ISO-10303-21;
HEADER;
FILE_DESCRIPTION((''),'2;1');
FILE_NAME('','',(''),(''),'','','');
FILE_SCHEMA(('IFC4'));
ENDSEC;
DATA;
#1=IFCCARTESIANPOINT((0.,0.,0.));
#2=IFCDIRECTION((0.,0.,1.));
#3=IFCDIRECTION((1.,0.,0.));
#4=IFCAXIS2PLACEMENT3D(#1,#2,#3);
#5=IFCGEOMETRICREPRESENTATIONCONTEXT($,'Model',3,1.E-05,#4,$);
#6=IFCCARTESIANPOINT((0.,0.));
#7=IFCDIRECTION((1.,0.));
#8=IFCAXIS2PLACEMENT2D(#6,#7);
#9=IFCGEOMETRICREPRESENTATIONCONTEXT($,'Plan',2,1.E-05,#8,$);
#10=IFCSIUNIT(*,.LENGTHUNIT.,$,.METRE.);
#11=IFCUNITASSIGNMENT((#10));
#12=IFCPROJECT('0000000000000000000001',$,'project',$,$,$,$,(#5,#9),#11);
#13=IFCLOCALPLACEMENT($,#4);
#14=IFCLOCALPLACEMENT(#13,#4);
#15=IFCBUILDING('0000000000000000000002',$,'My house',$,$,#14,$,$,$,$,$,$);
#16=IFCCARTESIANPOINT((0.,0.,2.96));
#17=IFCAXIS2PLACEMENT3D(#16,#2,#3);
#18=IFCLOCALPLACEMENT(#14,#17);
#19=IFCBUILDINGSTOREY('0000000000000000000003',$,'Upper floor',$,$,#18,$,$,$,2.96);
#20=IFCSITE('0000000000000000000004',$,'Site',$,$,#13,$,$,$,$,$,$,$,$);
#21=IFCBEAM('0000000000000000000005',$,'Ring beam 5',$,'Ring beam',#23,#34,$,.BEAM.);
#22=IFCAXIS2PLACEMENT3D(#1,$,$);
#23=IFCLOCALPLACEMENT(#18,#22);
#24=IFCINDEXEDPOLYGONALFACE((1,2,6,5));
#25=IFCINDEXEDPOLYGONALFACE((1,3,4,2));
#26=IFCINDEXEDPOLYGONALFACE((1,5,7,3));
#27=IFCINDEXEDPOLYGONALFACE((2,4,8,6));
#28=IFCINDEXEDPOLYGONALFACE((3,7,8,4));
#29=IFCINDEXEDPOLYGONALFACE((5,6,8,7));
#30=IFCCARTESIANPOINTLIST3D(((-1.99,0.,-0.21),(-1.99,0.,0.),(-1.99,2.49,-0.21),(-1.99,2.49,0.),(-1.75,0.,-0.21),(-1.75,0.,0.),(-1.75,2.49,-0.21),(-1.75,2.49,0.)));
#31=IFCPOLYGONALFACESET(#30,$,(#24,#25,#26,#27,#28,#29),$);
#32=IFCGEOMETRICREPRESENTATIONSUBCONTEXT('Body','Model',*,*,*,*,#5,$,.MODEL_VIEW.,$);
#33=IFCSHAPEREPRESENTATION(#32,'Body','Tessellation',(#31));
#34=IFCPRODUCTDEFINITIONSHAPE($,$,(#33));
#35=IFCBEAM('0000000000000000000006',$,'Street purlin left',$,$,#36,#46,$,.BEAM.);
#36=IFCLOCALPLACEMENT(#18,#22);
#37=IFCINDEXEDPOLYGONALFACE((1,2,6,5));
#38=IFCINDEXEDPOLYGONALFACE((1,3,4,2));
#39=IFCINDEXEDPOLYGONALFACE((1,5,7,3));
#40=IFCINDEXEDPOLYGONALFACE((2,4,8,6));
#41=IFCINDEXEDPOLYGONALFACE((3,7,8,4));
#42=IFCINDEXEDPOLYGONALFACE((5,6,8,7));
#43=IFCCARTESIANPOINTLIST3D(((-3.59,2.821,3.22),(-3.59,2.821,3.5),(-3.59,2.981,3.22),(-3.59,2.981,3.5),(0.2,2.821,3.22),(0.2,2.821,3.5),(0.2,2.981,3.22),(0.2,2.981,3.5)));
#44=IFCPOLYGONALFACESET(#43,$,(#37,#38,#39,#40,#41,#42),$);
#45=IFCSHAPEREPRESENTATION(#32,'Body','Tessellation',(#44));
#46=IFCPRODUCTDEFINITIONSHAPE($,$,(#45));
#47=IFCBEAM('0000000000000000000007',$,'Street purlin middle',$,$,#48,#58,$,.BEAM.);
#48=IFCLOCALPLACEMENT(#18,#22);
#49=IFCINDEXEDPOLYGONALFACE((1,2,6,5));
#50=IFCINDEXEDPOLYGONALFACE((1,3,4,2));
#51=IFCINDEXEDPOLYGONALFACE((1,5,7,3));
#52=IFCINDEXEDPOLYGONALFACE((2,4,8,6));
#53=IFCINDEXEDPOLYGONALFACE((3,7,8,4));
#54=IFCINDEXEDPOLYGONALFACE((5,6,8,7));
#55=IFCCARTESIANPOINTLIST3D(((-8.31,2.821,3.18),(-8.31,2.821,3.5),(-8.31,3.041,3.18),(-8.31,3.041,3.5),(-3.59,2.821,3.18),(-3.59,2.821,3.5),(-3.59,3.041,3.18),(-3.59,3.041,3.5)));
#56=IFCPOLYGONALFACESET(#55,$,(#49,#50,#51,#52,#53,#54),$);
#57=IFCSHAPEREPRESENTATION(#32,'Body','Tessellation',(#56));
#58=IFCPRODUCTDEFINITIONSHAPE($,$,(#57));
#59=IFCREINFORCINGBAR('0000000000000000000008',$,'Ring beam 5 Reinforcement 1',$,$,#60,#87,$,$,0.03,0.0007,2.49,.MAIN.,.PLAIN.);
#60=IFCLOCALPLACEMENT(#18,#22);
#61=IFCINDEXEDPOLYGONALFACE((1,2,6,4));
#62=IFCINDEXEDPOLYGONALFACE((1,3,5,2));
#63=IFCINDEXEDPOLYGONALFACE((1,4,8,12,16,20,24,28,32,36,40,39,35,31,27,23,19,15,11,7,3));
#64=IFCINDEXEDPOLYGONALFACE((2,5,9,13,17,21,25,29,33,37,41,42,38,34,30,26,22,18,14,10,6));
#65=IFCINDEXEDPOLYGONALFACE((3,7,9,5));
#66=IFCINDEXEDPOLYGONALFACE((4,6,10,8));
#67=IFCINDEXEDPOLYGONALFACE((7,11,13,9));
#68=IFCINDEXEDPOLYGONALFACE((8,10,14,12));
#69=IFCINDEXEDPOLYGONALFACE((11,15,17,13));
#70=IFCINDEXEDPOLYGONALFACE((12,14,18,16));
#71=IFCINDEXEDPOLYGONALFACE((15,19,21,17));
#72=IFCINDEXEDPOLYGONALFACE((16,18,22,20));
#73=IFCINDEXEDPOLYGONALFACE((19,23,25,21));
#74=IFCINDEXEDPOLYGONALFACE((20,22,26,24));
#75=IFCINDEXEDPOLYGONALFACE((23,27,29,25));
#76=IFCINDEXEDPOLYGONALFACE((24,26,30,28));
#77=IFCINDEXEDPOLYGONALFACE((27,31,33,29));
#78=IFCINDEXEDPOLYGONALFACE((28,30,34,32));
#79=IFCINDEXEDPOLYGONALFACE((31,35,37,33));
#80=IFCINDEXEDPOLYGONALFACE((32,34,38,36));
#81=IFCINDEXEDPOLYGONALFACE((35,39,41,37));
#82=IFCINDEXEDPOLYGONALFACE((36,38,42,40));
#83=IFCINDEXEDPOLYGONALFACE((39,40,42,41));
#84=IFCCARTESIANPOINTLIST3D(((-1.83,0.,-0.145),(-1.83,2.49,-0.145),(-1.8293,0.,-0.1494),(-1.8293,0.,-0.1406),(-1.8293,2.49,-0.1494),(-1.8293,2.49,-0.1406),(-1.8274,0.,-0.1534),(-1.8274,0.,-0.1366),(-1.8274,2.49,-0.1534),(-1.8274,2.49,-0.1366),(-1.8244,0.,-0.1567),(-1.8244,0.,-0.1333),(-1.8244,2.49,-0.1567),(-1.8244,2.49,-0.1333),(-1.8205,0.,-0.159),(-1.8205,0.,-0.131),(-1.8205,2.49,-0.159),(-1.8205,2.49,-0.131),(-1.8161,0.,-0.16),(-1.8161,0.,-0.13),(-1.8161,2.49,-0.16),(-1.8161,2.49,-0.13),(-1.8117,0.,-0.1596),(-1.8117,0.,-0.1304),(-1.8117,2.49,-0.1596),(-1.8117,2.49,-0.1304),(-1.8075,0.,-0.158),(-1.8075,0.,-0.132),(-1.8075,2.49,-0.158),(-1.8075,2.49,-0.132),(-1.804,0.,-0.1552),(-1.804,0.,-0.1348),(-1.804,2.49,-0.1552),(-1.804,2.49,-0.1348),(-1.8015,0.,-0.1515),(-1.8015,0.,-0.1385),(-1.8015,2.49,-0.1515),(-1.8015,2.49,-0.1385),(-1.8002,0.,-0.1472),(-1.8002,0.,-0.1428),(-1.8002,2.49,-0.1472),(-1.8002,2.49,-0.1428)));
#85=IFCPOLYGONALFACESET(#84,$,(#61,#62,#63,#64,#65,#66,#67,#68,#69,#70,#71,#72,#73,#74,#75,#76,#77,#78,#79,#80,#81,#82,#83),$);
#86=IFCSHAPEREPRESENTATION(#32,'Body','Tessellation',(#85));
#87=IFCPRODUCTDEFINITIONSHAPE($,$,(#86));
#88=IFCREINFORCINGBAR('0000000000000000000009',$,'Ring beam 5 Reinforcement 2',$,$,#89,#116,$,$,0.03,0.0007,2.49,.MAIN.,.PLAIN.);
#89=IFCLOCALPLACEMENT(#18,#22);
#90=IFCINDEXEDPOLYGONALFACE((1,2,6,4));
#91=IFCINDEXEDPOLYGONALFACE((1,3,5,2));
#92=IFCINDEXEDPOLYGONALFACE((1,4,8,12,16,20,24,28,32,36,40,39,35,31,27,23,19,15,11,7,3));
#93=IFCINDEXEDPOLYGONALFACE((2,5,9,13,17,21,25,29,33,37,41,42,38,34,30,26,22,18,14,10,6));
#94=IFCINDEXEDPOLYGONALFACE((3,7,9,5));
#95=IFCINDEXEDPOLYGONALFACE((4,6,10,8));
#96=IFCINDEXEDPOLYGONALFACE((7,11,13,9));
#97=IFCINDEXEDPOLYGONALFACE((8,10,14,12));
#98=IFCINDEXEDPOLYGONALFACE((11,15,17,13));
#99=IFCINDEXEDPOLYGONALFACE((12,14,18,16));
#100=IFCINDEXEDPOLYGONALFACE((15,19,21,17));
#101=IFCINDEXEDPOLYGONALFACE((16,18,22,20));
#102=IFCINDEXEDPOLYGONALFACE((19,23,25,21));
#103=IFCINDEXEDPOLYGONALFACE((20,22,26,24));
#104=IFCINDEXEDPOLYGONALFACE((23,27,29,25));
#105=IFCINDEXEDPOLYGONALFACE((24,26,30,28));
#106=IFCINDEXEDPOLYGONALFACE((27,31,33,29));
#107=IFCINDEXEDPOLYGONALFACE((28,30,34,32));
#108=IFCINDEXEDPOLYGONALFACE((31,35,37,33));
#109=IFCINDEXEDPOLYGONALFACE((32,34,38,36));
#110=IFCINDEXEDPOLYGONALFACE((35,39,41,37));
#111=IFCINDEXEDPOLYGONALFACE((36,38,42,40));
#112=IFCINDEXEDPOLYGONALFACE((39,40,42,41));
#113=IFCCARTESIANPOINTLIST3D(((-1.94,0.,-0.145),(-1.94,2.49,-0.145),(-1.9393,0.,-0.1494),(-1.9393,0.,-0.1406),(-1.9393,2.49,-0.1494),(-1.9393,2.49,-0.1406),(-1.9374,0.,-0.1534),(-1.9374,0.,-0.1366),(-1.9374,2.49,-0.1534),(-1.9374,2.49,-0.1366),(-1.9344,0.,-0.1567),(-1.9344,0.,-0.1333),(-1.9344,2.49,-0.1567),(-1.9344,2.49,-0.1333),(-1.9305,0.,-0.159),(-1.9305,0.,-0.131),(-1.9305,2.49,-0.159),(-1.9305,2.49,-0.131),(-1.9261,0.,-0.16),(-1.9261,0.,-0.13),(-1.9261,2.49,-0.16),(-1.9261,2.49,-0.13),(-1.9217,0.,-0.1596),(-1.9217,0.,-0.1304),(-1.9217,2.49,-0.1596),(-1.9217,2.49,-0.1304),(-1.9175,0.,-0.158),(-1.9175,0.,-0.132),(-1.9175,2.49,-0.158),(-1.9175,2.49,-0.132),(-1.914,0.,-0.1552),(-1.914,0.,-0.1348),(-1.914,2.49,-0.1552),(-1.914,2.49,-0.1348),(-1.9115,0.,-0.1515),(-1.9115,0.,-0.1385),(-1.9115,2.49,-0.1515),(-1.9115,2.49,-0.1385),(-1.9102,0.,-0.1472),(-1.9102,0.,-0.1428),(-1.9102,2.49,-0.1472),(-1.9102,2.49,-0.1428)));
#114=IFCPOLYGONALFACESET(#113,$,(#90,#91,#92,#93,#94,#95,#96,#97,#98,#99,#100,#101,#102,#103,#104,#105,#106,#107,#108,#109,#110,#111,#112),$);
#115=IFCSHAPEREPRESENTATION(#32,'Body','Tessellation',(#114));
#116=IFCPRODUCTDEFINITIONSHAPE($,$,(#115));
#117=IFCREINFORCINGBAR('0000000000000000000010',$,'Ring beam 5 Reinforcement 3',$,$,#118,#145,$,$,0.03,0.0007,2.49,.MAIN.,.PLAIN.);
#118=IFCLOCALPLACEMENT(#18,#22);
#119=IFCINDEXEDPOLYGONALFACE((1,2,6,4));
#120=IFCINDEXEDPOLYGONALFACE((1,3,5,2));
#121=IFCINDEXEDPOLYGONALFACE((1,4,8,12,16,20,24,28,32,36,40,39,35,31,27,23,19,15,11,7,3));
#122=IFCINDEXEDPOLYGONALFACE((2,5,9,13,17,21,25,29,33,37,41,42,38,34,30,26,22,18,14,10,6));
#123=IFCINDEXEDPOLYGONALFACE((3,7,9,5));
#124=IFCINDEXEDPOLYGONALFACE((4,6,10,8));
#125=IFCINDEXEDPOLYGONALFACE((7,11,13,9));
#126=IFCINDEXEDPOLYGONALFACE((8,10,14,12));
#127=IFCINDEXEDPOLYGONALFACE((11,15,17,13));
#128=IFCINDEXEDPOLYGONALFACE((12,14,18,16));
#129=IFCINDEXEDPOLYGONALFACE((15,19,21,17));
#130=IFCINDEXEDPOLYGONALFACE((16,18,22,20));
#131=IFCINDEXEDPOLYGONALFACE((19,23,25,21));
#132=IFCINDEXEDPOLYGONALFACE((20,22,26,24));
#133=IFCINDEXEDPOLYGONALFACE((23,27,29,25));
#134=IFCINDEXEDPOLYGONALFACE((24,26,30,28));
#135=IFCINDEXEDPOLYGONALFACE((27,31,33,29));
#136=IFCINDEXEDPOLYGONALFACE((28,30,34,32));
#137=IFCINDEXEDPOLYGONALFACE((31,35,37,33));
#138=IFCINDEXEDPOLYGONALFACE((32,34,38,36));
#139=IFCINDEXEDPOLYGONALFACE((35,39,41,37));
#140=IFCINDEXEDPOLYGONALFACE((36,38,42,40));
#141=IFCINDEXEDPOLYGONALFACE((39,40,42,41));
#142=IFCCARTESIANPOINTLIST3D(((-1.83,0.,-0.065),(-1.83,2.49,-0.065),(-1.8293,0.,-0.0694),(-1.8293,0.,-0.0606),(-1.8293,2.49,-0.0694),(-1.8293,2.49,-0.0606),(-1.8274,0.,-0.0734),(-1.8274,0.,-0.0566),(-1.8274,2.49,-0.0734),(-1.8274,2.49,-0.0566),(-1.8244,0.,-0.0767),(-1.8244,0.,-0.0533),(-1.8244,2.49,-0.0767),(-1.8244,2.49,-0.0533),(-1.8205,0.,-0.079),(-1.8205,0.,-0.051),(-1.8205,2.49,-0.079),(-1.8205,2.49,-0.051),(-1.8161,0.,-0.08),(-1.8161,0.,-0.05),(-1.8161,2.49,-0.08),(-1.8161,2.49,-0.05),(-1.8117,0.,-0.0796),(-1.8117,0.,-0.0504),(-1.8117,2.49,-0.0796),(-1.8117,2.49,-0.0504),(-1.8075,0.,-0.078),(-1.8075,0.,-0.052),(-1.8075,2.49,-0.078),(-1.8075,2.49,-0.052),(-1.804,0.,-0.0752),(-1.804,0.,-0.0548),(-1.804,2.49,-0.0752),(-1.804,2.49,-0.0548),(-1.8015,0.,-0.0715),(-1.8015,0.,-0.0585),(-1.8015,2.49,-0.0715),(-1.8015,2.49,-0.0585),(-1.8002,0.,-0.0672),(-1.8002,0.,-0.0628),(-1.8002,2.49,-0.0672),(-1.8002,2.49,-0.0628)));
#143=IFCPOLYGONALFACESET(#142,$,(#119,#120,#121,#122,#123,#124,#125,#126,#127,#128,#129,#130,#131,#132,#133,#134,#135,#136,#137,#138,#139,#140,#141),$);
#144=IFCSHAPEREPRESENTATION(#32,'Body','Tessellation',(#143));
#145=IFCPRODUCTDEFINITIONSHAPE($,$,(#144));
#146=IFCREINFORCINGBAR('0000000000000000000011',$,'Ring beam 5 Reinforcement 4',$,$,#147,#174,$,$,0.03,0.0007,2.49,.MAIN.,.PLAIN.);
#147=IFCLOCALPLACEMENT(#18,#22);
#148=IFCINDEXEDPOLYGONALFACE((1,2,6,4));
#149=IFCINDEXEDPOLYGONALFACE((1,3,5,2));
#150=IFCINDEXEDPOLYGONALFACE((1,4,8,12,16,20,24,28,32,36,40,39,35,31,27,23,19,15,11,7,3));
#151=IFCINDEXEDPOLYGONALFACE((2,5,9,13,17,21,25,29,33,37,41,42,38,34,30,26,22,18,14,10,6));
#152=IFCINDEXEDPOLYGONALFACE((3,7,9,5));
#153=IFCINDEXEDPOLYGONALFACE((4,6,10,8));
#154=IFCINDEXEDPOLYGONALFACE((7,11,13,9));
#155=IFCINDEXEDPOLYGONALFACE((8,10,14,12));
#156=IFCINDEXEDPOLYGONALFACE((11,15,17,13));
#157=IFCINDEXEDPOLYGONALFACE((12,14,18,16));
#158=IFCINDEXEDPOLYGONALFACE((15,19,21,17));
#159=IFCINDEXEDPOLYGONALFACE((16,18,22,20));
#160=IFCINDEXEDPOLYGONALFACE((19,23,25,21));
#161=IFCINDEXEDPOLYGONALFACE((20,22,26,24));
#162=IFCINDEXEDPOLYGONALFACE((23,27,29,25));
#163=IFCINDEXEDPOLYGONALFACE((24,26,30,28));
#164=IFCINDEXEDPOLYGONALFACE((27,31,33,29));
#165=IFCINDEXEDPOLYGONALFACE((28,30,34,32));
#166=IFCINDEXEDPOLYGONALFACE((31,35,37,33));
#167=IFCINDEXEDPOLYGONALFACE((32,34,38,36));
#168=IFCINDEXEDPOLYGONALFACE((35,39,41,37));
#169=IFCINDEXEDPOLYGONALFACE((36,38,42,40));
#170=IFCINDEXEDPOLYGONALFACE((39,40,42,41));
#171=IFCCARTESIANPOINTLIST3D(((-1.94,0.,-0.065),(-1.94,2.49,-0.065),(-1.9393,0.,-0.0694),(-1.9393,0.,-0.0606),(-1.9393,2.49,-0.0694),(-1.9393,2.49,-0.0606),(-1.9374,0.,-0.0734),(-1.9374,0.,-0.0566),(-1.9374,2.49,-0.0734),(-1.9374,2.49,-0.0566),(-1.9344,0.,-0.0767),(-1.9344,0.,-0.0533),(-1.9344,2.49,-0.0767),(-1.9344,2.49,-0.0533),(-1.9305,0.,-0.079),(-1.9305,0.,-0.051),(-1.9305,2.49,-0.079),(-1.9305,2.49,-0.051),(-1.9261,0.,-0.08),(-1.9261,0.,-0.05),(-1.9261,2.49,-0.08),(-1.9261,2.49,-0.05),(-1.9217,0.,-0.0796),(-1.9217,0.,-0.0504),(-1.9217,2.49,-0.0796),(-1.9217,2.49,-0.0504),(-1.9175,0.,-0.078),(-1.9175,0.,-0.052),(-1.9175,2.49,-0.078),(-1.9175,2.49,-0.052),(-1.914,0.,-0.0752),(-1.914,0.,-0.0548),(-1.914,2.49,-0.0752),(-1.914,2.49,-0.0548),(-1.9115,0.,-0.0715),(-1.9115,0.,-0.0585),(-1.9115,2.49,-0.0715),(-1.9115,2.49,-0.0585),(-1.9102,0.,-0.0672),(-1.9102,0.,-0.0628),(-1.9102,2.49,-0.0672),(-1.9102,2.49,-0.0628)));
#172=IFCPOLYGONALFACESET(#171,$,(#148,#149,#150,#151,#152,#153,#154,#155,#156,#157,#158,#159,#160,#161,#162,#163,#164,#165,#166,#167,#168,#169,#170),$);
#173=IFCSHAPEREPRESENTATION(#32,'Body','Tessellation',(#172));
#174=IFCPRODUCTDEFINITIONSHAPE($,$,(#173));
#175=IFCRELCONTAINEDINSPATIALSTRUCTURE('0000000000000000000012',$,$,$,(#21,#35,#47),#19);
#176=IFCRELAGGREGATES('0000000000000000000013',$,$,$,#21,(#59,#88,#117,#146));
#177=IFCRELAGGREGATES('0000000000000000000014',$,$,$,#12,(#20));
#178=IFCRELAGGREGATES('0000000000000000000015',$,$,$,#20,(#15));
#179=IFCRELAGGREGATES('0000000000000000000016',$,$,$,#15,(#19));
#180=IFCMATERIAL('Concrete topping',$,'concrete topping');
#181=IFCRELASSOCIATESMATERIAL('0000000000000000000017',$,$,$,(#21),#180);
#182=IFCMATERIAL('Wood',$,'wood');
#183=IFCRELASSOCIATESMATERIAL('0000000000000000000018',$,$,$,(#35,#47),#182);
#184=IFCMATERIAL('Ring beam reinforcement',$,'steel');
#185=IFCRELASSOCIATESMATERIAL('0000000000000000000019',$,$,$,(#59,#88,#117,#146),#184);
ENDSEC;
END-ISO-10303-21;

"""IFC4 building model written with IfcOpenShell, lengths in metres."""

from ifc_helpers import new_model, si_unit, frame, origin_with_axes, origin_2d, origin_2d_with_axis, place, context, subcontext, project, spatial, circle_curve, rectangle, outline, extrude, source, transform, mapped, material, element, aggregate, save


model = new_model("IFC4")

# Units and contexts
model_context = context("Model", 3, precision=1e-05, world=origin_with_axes())
plan_context = context("Plan", 2, precision=1e-05, world=origin_2d_with_axis())
body_context_1 = subcontext(model_context, "Body", "Model", "MODEL_VIEW")
ifc_project = project(units=[si_unit("LENGTHUNIT", "METRE")], contexts=[model_context, plan_context])

# Site, building, storey
site_placement = place(None, origin_with_axes())
site = spatial("IfcSite", under=ifc_project, at=site_placement, Name="Site")
building_placement = place(site_placement, origin_with_axes())
building = spatial("IfcBuilding", under=site, at=building_placement, Name="My house")
storey_placement = place(building_placement, frame((0.0, 0.0, 2.96), z_axis=(0.0, 0.0, 1.0), x_axis=(1.0, 0.0, 0.0)))
storey = spatial("IfcBuildingStorey", under=building, at=storey_placement, Name="Upper floor", Elevation=2.96)

# Beam
ifc_material_1 = material(Name="Concrete topping", Category="concrete topping")
shared_shape_1 = source(origin_with_axes(), body_context_1, "Body", "SweptSolid", [
    extrude(rectangle(XDim=0.24, YDim=0.21), frame((0.0, 0.0, 0.0), z_axis=(1.0, 0.0, 0.0), x_axis=(0.0, 1.0, 0.0)), (0.0, 0.0, 1.0), 2.49),
])
beam_1_placement = place(storey_placement, frame((-1.87, 2.49, -0.105), z_axis=(0.0, 0.0, 1.0), x_axis=(0.0, 1.0, 0.0)))
beam_1 = element("IfcBeam", 1, at=beam_1_placement, inside=storey, material=ifc_material_1, Name="Ring beam 5", ObjectType="Ring beam", PredefinedType="BEAM", context=body_context_1, shape_type="MappedRepresentation", body=[
    mapped(shared_shape_1, transform((0.0, 0.0, 0.0), x_axis=(-1.0, 0.0, 0.0), y_axis=(0.0, 1.0, 0.0), z_axis=(0.0, 0.0, 1.0), scale=1.0)),
])

# Beams
ifc_material_2 = material(Name="Wood", Category="wood")
shared_shape_2 = source(origin_with_axes(), body_context_1, "Body", "SweptSolid", [
    extrude(rectangle(XDim=0.16, YDim=0.28), frame((0.0, 0.0, 0.0), z_axis=(1.0, 0.0, 0.0), x_axis=(0.0, 1.0, 0.0)), (0.0, 0.0, 1.0), 3.79),
])
beam_2_placement = place(storey_placement, frame((0.2, 2.901, 3.36), z_axis=(0.0, 0.0, 1.0), x_axis=(1.0, 0.0, 0.0)))
element("IfcBeam", 2, at=beam_2_placement, inside=storey, material=ifc_material_2, Name="Street purlin left", PredefinedType="BEAM", context=body_context_1, shape_type="MappedRepresentation", body=[
    mapped(shared_shape_2, transform((0.0, 0.0, 0.0), x_axis=(-1.0, 0.0, 0.0), y_axis=(0.0, 1.0, 0.0), z_axis=(0.0, 0.0, 1.0), scale=1.0)),
])
shared_shape_3 = source(origin_with_axes(), body_context_1, "Body", "SweptSolid", [
    extrude(rectangle(XDim=0.22, YDim=0.32), frame((0.0, 0.0, 0.0), z_axis=(1.0, 0.0, 0.0), x_axis=(0.0, 1.0, 0.0)), (0.0, 0.0, 1.0), 4.72),
])
beam_3_placement = place(storey_placement, frame((-3.59, 2.931, 3.34), z_axis=(0.0, 0.0, 1.0), x_axis=(1.0, 0.0, 0.0)))
element("IfcBeam", 3, at=beam_3_placement, inside=storey, material=ifc_material_2, Name="Street purlin middle", PredefinedType="BEAM", context=body_context_1, shape_type="MappedRepresentation", body=[
    mapped(shared_shape_3, transform((0.0, 0.0, 0.0), x_axis=(-1.0, 0.0, 0.0), y_axis=(0.0, 1.0, 0.0), z_axis=(0.0, 0.0, 1.0), scale=1.0)),
])

# Reinforcing bars
ifc_material_3 = material(Name="Ring beam reinforcement", Category="steel")
shared_shape_4 = source(origin_with_axes(), body_context_1, "Body", "SweptSolid", [
    extrude(outline(circle_curve(origin_2d(), 0.015)), frame((0.0, 0.0, 0.0), z_axis=(1.0, 0.0, 0.0), x_axis=(0.0, 1.0, 0.0)), (0.0, 0.0, 1.0), 2.49),
])
reinforcing_bar_1_placement = place(beam_1_placement, frame((0.0, -0.055, -0.04), z_axis=(0.0, 0.0, 1.0), x_axis=(1.0, 0.0, 0.0)))
reinforcing_bar_1 = element("IfcReinforcingBar", 4, at=reinforcing_bar_1_placement, material=ifc_material_3, Name="Ring beam 5 Reinforcement 1", BarLength=2.49, BarSurface="PLAIN", CrossSectionArea=0.0007, NominalDiameter=0.03, PredefinedType="MAIN", context=body_context_1, shape_type="MappedRepresentation", body=[
    mapped(shared_shape_4, transform((0.0, 0.0, 0.0), x_axis=(-1.0, 0.0, 0.0), y_axis=(0.0, 1.0, 0.0), z_axis=(0.0, 0.0, 1.0), scale=1.0)),
])
shared_shape_5 = source(origin_with_axes(), body_context_1, "Body", "SweptSolid", [
    extrude(outline(circle_curve(origin_2d(), 0.015)), frame((0.0, 0.0, 0.0), z_axis=(1.0, 0.0, 0.0), x_axis=(0.0, 1.0, 0.0)), (0.0, 0.0, 1.0), 2.49),
])
reinforcing_bar_2_placement = place(beam_1_placement, frame((0.0, 0.055, -0.04), z_axis=(0.0, 0.0, 1.0), x_axis=(1.0, 0.0, 0.0)))
reinforcing_bar_2 = element("IfcReinforcingBar", 5, at=reinforcing_bar_2_placement, material=ifc_material_3, Name="Ring beam 5 Reinforcement 2", BarLength=2.49, BarSurface="PLAIN", CrossSectionArea=0.0007, NominalDiameter=0.03, PredefinedType="MAIN", context=body_context_1, shape_type="MappedRepresentation", body=[
    mapped(shared_shape_5, transform((0.0, 0.0, 0.0), x_axis=(-1.0, 0.0, 0.0), y_axis=(0.0, 1.0, 0.0), z_axis=(0.0, 0.0, 1.0), scale=1.0)),
])
shared_shape_6 = source(origin_with_axes(), body_context_1, "Body", "SweptSolid", [
    extrude(outline(circle_curve(origin_2d(), 0.015)), frame((0.0, 0.0, 0.0), z_axis=(1.0, 0.0, 0.0), x_axis=(0.0, 1.0, 0.0)), (0.0, 0.0, 1.0), 2.49),
])
reinforcing_bar_3_placement = place(beam_1_placement, frame((0.0, -0.055, 0.04), z_axis=(0.0, 0.0, 1.0), x_axis=(1.0, 0.0, 0.0)))
reinforcing_bar_3 = element("IfcReinforcingBar", 6, at=reinforcing_bar_3_placement, material=ifc_material_3, Name="Ring beam 5 Reinforcement 3", BarLength=2.49, BarSurface="PLAIN", CrossSectionArea=0.0007, NominalDiameter=0.03, PredefinedType="MAIN", context=body_context_1, shape_type="MappedRepresentation", body=[
    mapped(shared_shape_6, transform((0.0, 0.0, 0.0), x_axis=(-1.0, 0.0, 0.0), y_axis=(0.0, 1.0, 0.0), z_axis=(0.0, 0.0, 1.0), scale=1.0)),
])
shared_shape_7 = source(origin_with_axes(), body_context_1, "Body", "SweptSolid", [
    extrude(outline(circle_curve(origin_2d(), 0.015)), frame((0.0, 0.0, 0.0), z_axis=(1.0, 0.0, 0.0), x_axis=(0.0, 1.0, 0.0)), (0.0, 0.0, 1.0), 2.49),
])
reinforcing_bar_4_placement = place(beam_1_placement, frame((0.0, 0.055, 0.04), z_axis=(0.0, 0.0, 1.0), x_axis=(1.0, 0.0, 0.0)))
reinforcing_bar_4 = element("IfcReinforcingBar", 7, at=reinforcing_bar_4_placement, material=ifc_material_3, Name="Ring beam 5 Reinforcement 4", BarLength=2.49, BarSurface="PLAIN", CrossSectionArea=0.0007, NominalDiameter=0.03, PredefinedType="MAIN", context=body_context_1, shape_type="MappedRepresentation", body=[
    mapped(shared_shape_7, transform((0.0, 0.0, 0.0), x_axis=(-1.0, 0.0, 0.0), y_axis=(0.0, 1.0, 0.0), z_axis=(0.0, 0.0, 1.0), scale=1.0)),
])
aggregate(beam_1, [reinforcing_bar_1, reinforcing_bar_2, reinforcing_bar_3, reinforcing_bar_4])

save(model, "model.ifc")
